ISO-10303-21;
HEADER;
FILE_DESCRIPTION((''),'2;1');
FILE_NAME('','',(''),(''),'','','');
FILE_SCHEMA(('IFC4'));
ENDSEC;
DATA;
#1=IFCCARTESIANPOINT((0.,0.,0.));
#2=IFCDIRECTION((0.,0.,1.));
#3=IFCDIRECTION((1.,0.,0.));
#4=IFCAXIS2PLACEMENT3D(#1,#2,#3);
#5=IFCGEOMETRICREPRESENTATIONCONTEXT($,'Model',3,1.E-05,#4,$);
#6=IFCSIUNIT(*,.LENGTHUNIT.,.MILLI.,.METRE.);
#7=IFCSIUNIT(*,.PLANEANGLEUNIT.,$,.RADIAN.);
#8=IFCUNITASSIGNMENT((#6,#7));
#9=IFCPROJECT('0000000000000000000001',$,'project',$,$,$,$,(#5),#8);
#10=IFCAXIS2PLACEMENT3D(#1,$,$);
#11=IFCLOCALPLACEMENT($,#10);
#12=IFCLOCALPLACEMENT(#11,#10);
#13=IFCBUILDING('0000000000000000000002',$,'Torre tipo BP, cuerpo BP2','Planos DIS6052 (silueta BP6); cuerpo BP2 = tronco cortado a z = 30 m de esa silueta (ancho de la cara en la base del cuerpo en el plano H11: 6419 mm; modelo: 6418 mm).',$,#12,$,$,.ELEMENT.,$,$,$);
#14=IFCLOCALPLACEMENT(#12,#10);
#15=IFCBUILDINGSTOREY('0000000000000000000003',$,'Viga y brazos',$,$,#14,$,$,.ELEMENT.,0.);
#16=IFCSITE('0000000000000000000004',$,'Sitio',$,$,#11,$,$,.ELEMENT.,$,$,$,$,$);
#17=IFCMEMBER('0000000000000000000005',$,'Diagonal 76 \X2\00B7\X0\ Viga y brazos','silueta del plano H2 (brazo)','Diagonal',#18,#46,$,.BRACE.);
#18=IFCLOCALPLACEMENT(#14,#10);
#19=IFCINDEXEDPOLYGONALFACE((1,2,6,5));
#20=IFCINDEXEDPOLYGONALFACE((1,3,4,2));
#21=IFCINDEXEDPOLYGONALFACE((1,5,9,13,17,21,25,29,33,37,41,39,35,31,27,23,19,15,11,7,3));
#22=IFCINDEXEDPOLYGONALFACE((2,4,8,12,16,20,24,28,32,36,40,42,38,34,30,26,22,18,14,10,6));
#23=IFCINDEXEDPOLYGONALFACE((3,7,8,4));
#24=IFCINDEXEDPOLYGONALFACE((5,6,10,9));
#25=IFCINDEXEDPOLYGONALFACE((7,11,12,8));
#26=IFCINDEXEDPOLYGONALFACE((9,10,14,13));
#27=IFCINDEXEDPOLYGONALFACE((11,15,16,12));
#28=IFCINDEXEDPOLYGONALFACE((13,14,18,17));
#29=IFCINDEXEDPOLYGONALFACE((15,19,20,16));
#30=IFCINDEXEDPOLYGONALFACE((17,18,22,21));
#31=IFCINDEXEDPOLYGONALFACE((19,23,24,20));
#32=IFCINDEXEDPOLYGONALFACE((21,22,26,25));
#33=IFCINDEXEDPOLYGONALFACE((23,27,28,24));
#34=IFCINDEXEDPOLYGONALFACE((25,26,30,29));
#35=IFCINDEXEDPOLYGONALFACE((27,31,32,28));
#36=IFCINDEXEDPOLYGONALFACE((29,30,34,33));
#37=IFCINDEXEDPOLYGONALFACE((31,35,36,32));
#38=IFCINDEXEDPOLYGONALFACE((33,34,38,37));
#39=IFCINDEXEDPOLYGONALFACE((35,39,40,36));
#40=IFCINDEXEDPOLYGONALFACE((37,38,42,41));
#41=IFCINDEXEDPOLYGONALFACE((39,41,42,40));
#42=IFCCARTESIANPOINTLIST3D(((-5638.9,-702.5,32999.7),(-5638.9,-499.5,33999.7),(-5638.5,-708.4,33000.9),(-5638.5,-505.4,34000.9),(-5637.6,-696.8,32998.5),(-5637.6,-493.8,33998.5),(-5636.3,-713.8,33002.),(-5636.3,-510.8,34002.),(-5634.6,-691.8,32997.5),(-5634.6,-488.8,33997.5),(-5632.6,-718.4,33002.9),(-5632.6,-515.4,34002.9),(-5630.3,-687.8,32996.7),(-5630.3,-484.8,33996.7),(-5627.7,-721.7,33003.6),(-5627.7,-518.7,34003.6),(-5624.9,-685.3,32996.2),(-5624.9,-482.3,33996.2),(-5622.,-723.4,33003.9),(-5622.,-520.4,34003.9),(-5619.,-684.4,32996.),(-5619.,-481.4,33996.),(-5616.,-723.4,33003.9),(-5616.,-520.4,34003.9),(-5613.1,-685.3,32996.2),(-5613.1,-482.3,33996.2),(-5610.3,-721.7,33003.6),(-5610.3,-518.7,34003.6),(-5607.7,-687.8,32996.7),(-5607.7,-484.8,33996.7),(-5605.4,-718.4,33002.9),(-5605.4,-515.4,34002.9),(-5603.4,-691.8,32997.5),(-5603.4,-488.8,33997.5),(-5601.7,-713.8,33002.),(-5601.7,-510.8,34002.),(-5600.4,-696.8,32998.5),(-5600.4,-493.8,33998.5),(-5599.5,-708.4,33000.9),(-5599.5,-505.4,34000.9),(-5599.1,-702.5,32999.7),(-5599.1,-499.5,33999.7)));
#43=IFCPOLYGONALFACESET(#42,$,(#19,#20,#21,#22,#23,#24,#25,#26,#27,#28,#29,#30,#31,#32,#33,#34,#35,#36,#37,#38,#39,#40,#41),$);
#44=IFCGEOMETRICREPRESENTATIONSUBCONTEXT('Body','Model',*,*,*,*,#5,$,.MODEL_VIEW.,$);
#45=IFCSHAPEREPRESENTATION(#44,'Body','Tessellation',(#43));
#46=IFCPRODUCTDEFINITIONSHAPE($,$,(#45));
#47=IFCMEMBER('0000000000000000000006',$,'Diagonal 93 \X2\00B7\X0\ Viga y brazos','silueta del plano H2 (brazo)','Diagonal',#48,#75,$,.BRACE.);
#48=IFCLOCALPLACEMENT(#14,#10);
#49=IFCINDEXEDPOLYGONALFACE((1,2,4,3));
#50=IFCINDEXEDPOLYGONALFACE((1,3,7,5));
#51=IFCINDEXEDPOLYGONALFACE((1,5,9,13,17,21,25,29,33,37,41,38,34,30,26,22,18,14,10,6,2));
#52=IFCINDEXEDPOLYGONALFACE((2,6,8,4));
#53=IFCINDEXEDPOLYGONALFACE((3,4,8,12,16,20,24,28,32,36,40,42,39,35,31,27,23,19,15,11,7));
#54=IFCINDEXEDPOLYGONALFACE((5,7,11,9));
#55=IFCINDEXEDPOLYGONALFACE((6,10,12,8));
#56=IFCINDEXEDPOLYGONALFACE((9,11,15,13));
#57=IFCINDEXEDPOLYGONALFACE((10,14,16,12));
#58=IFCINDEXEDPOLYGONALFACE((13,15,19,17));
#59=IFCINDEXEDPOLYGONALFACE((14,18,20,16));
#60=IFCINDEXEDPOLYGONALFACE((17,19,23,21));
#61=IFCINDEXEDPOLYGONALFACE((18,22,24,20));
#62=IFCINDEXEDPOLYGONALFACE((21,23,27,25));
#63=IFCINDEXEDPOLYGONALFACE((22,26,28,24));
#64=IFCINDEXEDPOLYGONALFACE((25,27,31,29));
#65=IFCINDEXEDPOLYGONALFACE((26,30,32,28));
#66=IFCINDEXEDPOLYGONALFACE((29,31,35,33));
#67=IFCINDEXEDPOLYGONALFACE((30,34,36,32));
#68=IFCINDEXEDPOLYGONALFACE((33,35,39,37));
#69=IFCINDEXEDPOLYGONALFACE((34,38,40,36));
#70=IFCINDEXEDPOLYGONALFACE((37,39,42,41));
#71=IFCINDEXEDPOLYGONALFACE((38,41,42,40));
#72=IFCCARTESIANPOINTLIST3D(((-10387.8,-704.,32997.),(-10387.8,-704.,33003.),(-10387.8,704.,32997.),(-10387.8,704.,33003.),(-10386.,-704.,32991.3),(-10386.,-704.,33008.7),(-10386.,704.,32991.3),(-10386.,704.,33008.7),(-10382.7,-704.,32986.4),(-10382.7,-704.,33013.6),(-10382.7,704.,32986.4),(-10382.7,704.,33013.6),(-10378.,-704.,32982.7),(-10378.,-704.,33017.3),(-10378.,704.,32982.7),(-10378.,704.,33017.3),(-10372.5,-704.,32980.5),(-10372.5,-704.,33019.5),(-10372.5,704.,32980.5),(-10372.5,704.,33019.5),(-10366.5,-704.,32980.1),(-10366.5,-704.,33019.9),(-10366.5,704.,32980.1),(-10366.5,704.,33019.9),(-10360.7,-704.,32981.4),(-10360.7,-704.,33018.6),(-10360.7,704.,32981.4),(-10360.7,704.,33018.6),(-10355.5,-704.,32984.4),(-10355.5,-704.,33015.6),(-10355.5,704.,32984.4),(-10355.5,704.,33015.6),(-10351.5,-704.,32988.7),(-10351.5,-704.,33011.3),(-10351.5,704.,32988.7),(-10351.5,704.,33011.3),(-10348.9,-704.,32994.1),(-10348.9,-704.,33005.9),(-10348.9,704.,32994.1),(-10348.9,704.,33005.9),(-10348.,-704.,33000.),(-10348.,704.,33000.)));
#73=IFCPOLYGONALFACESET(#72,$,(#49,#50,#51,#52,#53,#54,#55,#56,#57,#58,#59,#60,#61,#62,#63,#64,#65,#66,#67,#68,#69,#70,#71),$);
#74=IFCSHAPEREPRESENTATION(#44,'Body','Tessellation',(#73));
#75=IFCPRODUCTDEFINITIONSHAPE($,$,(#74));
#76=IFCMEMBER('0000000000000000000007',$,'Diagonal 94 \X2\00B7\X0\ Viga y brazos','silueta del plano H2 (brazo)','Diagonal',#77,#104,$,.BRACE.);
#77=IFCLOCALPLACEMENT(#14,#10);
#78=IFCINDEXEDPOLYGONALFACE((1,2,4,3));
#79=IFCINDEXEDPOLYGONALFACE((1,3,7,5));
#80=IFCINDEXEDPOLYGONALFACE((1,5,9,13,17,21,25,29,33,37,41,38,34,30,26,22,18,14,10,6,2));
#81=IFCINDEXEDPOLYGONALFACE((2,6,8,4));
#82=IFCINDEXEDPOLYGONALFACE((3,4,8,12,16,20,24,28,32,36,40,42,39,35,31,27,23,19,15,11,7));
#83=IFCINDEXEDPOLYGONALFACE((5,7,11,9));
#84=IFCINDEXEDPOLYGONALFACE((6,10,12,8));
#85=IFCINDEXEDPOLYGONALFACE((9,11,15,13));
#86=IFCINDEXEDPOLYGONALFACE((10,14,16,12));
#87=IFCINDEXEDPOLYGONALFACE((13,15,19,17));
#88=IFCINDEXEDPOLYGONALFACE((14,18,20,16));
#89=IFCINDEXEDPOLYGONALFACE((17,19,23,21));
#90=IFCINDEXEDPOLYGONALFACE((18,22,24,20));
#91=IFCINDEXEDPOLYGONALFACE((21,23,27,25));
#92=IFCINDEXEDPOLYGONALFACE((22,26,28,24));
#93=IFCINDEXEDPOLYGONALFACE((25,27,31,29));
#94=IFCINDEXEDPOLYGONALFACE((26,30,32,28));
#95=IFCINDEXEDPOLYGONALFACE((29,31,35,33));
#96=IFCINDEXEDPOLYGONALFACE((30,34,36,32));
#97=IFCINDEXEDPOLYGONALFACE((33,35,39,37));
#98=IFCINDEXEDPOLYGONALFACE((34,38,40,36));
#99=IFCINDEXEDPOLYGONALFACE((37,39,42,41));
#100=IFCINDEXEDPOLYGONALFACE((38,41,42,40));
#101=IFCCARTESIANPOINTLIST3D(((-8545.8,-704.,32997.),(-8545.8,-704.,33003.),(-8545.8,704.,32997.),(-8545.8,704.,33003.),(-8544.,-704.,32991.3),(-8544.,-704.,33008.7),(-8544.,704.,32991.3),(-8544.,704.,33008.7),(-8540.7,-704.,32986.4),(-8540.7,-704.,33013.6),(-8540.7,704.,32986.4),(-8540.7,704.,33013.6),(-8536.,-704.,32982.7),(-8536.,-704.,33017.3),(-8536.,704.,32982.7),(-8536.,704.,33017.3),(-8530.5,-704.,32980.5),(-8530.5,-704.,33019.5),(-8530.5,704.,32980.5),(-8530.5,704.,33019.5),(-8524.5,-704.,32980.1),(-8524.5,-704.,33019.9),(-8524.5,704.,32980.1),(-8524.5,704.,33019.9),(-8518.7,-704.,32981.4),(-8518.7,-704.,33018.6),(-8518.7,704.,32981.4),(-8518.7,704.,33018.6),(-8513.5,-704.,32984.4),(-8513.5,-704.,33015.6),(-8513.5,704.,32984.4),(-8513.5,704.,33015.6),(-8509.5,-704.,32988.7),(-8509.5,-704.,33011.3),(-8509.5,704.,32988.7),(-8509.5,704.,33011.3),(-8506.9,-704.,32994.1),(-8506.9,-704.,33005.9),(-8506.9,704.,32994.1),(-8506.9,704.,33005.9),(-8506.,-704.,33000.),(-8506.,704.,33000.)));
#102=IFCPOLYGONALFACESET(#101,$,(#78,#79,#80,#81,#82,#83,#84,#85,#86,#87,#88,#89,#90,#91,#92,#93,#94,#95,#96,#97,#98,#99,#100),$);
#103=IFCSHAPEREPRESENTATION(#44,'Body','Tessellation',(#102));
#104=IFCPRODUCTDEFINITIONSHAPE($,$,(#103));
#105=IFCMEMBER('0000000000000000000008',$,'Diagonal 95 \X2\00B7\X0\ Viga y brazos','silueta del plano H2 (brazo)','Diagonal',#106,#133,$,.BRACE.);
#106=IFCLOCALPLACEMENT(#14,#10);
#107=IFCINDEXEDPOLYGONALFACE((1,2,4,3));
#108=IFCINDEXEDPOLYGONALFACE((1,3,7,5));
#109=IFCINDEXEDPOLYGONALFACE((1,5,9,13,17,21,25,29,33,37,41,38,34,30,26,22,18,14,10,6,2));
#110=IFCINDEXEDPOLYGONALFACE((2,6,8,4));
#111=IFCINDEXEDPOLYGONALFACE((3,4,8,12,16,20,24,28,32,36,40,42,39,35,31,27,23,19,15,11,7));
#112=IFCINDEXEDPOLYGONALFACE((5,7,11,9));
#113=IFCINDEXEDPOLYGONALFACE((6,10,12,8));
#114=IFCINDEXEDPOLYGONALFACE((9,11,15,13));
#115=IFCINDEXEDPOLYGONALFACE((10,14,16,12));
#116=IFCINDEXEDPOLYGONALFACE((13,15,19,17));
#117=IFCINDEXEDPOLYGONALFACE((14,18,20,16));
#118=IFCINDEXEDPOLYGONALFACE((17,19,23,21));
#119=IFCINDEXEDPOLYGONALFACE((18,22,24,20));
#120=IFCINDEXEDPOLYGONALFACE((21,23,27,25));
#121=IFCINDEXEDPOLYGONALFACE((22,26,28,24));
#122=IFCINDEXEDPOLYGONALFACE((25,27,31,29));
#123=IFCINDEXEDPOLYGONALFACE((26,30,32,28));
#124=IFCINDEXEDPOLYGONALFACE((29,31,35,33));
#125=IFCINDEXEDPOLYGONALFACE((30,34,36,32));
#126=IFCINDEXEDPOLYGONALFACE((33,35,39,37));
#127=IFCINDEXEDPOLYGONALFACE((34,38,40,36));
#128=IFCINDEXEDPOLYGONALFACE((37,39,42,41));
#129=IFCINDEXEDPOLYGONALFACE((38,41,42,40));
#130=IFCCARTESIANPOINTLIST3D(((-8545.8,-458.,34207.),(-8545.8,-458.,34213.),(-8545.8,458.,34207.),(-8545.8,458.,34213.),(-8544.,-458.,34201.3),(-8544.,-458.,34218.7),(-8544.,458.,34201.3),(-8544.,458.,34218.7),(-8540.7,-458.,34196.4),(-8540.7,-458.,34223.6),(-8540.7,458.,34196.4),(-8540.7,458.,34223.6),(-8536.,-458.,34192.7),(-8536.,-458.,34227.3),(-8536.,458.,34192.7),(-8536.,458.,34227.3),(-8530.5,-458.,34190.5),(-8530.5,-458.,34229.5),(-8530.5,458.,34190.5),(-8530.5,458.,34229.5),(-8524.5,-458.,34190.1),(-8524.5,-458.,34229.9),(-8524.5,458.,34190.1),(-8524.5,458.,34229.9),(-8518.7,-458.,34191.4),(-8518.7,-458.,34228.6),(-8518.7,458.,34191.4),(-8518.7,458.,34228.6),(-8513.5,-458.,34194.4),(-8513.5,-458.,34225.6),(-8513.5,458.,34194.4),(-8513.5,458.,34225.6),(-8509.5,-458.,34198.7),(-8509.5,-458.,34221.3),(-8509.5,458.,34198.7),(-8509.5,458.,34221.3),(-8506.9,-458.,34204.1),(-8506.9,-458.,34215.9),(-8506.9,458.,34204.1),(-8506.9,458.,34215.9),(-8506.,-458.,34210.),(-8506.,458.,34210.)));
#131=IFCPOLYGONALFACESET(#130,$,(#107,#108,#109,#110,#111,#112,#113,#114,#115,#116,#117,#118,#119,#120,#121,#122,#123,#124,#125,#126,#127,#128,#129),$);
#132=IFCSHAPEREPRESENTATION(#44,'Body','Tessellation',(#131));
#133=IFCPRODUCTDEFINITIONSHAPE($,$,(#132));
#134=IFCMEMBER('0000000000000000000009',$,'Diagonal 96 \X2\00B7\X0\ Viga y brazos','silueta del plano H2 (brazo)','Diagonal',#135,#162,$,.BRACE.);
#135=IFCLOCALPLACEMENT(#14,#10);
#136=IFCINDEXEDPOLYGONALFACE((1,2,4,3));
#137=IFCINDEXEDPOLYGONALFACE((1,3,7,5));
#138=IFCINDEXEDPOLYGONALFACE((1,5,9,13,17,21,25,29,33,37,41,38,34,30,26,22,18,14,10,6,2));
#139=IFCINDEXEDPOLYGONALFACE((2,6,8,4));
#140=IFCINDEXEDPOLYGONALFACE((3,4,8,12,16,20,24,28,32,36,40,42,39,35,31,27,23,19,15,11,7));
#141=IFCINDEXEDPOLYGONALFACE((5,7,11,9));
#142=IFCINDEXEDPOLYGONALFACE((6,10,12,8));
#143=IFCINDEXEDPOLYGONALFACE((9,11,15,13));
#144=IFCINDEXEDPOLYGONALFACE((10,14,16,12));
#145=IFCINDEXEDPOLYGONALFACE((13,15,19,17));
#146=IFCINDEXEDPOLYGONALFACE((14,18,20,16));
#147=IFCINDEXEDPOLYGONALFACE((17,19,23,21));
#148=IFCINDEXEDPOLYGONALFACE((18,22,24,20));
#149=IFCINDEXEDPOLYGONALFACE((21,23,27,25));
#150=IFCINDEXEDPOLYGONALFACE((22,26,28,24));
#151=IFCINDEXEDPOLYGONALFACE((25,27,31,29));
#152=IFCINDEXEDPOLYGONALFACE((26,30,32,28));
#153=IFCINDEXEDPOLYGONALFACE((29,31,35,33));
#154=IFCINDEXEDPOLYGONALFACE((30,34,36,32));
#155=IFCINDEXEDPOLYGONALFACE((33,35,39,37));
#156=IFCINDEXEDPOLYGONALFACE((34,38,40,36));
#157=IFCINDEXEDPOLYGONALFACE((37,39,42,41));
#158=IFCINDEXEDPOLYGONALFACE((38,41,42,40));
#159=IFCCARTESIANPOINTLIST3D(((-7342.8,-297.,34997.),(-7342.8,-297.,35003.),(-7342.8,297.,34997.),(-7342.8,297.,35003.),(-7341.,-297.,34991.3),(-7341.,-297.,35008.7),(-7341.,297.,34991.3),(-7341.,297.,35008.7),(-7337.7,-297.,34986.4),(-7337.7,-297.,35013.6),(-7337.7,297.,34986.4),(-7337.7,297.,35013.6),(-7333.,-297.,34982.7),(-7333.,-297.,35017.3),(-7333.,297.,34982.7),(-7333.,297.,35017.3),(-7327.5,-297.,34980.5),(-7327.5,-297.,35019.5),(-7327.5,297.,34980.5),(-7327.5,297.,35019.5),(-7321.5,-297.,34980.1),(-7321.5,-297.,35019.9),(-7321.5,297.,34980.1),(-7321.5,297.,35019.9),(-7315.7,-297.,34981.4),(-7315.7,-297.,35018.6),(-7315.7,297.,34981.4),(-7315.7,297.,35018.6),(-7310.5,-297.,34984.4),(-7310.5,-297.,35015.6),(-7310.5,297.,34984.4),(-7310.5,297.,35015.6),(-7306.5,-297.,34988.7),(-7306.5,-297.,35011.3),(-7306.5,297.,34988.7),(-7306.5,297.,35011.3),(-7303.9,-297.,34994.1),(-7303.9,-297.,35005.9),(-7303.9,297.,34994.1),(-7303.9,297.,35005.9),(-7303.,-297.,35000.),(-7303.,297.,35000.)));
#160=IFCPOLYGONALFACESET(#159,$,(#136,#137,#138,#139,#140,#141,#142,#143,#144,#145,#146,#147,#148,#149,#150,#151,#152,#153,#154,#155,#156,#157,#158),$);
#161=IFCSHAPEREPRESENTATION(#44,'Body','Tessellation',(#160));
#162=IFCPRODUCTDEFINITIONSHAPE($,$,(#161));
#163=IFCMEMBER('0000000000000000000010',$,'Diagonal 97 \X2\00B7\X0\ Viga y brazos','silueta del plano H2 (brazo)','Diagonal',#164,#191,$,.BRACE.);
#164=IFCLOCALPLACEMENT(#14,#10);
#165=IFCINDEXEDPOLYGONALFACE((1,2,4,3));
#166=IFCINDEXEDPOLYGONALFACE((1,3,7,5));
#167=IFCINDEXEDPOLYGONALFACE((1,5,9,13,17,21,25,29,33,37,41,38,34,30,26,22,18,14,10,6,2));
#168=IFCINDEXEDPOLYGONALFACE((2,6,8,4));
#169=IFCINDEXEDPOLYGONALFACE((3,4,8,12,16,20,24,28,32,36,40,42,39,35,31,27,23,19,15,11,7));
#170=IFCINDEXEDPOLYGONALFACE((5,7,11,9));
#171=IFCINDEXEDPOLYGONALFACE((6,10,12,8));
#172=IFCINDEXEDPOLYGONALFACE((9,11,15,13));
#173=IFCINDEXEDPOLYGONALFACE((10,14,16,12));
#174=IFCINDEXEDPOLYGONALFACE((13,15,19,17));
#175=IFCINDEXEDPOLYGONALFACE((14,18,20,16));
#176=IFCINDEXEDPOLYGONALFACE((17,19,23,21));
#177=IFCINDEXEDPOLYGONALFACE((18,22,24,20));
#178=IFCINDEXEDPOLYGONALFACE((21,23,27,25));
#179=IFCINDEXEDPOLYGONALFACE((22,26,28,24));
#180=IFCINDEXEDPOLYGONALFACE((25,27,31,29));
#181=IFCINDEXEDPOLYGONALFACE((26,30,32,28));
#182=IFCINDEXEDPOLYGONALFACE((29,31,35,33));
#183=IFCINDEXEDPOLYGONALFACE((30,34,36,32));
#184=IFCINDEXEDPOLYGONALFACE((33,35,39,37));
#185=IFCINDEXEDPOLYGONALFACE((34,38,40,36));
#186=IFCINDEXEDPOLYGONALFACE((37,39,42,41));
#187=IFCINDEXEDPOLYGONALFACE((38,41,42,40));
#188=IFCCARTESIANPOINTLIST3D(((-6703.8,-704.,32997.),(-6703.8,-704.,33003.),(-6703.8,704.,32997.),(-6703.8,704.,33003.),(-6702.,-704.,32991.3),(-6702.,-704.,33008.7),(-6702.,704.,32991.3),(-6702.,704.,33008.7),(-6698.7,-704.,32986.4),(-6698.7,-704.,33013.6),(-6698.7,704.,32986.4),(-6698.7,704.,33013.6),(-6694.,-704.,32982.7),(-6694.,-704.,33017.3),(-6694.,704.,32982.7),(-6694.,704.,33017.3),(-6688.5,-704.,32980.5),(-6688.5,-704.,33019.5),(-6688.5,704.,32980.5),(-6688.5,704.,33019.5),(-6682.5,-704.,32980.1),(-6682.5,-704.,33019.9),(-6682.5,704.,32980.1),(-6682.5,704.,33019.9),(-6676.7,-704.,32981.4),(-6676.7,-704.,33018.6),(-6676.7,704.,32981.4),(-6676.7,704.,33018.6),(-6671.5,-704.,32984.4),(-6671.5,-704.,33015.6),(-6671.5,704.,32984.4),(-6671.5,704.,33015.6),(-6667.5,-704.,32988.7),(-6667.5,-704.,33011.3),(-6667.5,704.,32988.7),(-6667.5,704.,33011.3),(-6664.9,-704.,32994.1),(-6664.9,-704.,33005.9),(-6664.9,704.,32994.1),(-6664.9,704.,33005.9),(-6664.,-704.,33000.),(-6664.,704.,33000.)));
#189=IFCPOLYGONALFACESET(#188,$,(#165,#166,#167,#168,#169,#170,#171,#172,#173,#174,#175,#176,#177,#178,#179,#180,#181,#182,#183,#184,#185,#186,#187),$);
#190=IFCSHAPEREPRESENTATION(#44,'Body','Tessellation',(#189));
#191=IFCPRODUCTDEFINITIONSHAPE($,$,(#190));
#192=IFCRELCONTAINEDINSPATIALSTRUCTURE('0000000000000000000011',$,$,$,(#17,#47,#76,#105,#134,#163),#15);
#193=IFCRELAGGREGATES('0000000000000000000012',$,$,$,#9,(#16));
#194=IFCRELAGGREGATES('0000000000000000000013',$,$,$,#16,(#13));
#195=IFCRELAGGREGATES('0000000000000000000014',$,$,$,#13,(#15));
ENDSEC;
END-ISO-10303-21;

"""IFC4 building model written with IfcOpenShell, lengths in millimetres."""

from ifc_helpers import new_model, si_unit, frame, origin, origin_with_axes, place, context, subcontext, project, spatial, circle, extrude, element, save


model = new_model("IFC4")

# Units and contexts
model_context = context("Model", 3, precision=1e-05, world=origin_with_axes())
body_context = subcontext(model_context, "Body", "Model", "MODEL_VIEW")
ifc_project = project(units=[si_unit("LENGTHUNIT", "METRE", prefix="MILLI"), si_unit("PLANEANGLEUNIT", "RADIAN")], contexts=[model_context])

# Site, building, storey
site_placement = place(None, origin())
site = spatial("IfcSite", under=ifc_project, at=site_placement, Name="Sitio", CompositionType="ELEMENT")
building_placement = place(site_placement, origin())
building = spatial("IfcBuilding", under=site, at=building_placement, Name="Torre tipo BP, cuerpo BP2", Description="Planos DIS6052 (silueta BP6); cuerpo BP2 = tronco cortado a z = 30 m de esa silueta (ancho de la cara en la base del cuerpo en el plano H11: 6419 mm; modelo: 6418 mm).", CompositionType="ELEMENT")
storey_placement = place(building_placement, origin())
storey = spatial("IfcBuildingStorey", under=building, at=storey_placement, Name="Viga y brazos", CompositionType="ELEMENT", Elevation=0.0)

# Members
for number, where, z_axis, x_axis, name in (
    (1, (-5619.0, -704.0, 33000.0), (0.0, 0.198942, 0.980011), (0.0, 0.980011, -0.198942), "Diagonal 76 · Viga y brazos"),
):
    element("IfcMember", number, at=place(storey_placement, frame(where, z_axis=z_axis, x_axis=x_axis)), inside=storey, Name=name, Description="silueta del plano H2 (brazo)", ObjectType="Diagonal", PredefinedType="BRACE", context=body_context, shape_type="SweptSolid", body=[
        extrude(circle(Radius=20.0), None, (0.0, 0.0, 1.0), 1020.4),
    ])
for number, where, z_axis, x_axis, name in (
    (2, (-10368.0, 704.0, 33000.0), (0.0, -1.0, 0.0), (1.0, 0.0, 0.0), "Diagonal 93 · Viga y brazos"),
    (3, (-8526.0, 704.0, 33000.0), (0.0, -1.0, 0.0), (1.0, 0.0, 0.0), "Diagonal 94 · Viga y brazos"),
):
    element("IfcMember", number, at=place(storey_placement, frame(where, z_axis=z_axis, x_axis=x_axis)), inside=storey, Name=name, Description="silueta del plano H2 (brazo)", ObjectType="Diagonal", PredefinedType="BRACE", context=body_context, shape_type="SweptSolid", body=[
        extrude(circle(Radius=20.0), None, (0.0, 0.0, 1.0), 1408.0),
    ])
member_1_placement = place(storey_placement, frame((-8526.0, 458.0, 34210.0), z_axis=(0.0, -1.0, 0.0), x_axis=(1.0, 0.0, 0.0)))
element("IfcMember", 4, at=member_1_placement, inside=storey, Name="Diagonal 95 · Viga y brazos", Description="silueta del plano H2 (brazo)", ObjectType="Diagonal", PredefinedType="BRACE", context=body_context, shape_type="SweptSolid", body=[
    extrude(circle(Radius=20.0), None, (0.0, 0.0, 1.0), 916.0),
])
member_2_placement = place(storey_placement, frame((-7323.0, 297.0, 35000.0), z_axis=(0.0, -1.0, 0.0), x_axis=(1.0, 0.0, 0.0)))
element("IfcMember", 5, at=member_2_placement, inside=storey, Name="Diagonal 96 · Viga y brazos", Description="silueta del plano H2 (brazo)", ObjectType="Diagonal", PredefinedType="BRACE", context=body_context, shape_type="SweptSolid", body=[
    extrude(circle(Radius=20.0), None, (0.0, 0.0, 1.0), 594.0),
])
for number, where, z_axis, x_axis, name in (
    (6, (-6684.0, 704.0, 33000.0), (0.0, -1.0, 0.0), (1.0, 0.0, 0.0), "Diagonal 97 · Viga y brazos"),
):
    element("IfcMember", number, at=place(storey_placement, frame(where, z_axis=z_axis, x_axis=x_axis)), inside=storey, Name=name, Description="silueta del plano H2 (brazo)", ObjectType="Diagonal", PredefinedType="BRACE", context=body_context, shape_type="SweptSolid", body=[
        extrude(circle(Radius=20.0), None, (0.0, 0.0, 1.0), 1408.0),
    ])

save(model, "model.ifc")
